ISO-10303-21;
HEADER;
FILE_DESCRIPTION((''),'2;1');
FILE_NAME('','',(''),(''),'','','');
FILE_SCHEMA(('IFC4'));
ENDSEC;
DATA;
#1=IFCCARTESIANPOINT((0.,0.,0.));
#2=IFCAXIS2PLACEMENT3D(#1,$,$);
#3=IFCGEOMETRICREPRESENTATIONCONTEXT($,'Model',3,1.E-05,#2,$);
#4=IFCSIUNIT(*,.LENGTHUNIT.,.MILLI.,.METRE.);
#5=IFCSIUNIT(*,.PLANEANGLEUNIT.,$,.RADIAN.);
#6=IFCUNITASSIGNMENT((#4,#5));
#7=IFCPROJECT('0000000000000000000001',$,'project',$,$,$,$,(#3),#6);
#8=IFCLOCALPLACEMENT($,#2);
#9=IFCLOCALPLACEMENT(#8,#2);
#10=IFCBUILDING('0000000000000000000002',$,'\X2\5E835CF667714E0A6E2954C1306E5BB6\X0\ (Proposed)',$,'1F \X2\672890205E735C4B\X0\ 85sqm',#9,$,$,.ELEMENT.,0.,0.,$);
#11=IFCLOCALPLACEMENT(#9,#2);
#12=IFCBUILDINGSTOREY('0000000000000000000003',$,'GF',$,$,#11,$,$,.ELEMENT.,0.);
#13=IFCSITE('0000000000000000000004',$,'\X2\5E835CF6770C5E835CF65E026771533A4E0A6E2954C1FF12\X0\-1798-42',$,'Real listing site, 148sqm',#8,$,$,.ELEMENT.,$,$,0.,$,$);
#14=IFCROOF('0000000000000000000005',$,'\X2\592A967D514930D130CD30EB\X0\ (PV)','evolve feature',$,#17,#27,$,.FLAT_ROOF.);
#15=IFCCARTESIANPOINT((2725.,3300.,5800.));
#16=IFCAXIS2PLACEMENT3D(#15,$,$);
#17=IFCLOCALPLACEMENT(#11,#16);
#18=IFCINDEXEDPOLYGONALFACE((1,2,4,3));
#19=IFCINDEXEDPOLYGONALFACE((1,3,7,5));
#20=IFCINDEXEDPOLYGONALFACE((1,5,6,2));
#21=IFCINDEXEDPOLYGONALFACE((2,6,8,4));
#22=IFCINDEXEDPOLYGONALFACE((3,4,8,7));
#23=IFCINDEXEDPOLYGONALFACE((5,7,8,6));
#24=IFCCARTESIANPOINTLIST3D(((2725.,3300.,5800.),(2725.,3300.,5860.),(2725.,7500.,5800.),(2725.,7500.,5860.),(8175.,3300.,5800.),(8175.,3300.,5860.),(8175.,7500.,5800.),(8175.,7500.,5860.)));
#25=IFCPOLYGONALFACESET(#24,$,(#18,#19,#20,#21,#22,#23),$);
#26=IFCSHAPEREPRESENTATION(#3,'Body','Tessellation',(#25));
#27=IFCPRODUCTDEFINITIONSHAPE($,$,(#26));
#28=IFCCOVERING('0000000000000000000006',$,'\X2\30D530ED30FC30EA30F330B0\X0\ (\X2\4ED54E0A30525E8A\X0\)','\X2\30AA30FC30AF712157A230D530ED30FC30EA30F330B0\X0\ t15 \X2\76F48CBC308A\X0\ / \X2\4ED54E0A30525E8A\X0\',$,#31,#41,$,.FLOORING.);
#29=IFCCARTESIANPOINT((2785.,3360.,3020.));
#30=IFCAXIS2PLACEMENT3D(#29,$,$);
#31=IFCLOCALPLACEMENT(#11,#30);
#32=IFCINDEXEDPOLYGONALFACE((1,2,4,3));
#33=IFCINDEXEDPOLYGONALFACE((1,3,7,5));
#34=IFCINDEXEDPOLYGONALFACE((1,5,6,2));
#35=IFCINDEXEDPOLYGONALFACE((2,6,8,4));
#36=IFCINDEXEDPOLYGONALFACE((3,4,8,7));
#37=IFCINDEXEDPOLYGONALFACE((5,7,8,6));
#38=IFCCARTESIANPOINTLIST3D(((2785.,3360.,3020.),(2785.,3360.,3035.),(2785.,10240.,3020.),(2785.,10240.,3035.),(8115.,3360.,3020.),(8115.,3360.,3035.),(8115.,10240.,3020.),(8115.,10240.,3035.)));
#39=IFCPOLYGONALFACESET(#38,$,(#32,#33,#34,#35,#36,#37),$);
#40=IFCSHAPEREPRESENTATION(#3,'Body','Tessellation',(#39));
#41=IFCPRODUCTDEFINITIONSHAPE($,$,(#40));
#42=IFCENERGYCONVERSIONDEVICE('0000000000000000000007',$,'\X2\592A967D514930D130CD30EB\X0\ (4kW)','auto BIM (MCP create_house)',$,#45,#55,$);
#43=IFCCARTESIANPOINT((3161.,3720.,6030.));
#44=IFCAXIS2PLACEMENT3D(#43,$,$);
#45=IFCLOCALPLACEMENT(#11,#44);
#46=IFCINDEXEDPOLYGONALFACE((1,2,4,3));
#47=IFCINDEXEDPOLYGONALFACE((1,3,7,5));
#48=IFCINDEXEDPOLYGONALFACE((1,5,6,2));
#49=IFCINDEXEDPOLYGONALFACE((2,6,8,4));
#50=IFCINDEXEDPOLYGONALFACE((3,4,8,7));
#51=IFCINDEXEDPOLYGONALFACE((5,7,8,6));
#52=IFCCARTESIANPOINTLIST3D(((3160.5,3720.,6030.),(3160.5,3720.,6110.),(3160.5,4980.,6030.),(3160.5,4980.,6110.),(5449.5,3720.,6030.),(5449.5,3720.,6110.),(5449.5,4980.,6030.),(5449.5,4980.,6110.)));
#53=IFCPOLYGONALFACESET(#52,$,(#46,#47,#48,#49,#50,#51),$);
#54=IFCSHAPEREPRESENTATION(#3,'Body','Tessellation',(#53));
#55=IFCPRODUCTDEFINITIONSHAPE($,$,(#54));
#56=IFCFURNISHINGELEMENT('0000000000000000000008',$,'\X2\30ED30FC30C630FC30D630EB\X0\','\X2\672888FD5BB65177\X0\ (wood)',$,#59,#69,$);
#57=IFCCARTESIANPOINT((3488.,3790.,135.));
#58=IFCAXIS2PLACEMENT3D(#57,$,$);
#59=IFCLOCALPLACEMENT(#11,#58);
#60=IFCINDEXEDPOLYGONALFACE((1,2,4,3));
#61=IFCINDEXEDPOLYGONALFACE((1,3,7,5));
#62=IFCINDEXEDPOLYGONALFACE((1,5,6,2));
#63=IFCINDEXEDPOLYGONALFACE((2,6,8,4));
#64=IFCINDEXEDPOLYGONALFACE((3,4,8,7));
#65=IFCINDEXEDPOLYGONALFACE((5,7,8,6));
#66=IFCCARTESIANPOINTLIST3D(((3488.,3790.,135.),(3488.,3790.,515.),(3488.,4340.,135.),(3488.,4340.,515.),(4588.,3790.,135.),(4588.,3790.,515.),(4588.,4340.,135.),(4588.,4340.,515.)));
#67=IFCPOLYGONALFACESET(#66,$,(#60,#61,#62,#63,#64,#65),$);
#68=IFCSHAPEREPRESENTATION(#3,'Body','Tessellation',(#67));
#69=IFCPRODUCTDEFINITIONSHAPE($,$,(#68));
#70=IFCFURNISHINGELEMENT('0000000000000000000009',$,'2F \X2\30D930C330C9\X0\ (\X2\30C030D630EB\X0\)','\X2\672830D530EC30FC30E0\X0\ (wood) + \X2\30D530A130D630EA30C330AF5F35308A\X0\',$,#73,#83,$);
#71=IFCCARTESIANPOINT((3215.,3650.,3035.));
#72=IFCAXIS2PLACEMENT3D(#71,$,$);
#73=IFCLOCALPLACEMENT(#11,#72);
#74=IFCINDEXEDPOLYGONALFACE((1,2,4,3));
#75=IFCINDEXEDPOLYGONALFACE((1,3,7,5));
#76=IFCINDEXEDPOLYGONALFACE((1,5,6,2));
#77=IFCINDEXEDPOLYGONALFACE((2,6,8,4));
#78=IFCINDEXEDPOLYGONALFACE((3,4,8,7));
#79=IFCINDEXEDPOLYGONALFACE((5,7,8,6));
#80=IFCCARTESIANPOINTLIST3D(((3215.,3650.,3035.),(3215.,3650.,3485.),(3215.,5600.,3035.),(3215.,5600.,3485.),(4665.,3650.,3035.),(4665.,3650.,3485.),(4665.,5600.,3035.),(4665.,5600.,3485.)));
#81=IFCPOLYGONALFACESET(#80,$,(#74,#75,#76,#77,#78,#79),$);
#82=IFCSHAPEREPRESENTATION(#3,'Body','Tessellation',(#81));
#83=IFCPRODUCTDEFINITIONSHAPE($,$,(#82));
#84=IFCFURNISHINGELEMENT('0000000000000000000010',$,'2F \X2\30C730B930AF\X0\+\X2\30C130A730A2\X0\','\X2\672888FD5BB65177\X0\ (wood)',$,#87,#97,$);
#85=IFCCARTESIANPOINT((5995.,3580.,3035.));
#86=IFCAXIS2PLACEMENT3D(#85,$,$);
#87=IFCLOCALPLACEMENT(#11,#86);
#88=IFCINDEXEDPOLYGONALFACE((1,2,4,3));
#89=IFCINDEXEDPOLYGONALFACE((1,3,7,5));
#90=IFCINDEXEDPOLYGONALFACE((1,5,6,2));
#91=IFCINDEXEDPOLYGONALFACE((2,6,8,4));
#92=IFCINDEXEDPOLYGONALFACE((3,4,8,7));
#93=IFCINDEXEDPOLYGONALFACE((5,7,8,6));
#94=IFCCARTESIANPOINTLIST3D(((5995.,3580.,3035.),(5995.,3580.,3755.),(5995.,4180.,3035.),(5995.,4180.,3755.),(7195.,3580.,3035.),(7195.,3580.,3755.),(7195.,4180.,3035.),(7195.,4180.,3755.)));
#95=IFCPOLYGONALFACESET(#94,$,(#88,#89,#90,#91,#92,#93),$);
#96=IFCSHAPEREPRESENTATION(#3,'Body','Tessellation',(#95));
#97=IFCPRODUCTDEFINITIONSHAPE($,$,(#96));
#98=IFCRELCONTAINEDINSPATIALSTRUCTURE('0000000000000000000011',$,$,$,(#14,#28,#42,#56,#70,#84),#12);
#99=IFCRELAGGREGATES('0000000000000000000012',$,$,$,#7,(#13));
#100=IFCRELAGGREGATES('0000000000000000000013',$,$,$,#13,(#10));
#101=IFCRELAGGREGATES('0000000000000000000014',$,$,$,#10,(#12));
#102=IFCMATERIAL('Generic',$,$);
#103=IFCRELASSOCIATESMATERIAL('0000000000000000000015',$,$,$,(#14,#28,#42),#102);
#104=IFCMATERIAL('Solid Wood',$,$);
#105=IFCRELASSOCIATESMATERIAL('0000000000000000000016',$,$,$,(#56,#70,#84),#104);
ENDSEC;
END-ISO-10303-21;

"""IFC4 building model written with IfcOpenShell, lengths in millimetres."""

from ifc_helpers import new_model, si_unit, frame, frame_2d, origin, place, context, project, spatial, rectangle, extrude, material, element, save


model = new_model("IFC4")

# Units and contexts
model_context = context("Model", 3, precision=1e-05, world=origin())
ifc_project = project(units=[si_unit("LENGTHUNIT", "METRE", prefix="MILLI"), si_unit("PLANEANGLEUNIT", "RADIAN")], contexts=[model_context])

# Site, building, storey
site_placement = place(None, origin())
site = spatial("IfcSite", under=ifc_project, at=site_placement, Name="広島県広島市東区上温品２-1798-42", ObjectType="Real listing site, 148sqm", CompositionType="ELEMENT", RefElevation=0.0)
building_placement = place(site_placement, origin())
building = spatial("IfcBuilding", under=site, at=building_placement, Name="広島東上温品の家 (Proposed)", ObjectType="1F 木造平屋 85sqm", CompositionType="ELEMENT", ElevationOfRefHeight=0.0, ElevationOfTerrain=0.0)
storey_placement = place(building_placement, origin())
storey = spatial("IfcBuildingStorey", under=building, at=storey_placement, Name="GF", CompositionType="ELEMENT", Elevation=0.0)

# Shared definitions
ifc_material_1 = material(Name="Solid Wood")

# Shared definitions
ifc_material_2 = material(Name="Generic")

# Roof
roof_1_placement = place(storey_placement, frame((2725.0, 3300.0, 5800.0)))
element("IfcRoof", 1, at=roof_1_placement, inside=storey, material=ifc_material_2, Name="太陽光パネル (PV)", Description="evolve feature", PredefinedType="FLAT_ROOF", context=model_context, shape_type="SweptSolid", body=[
    extrude(rectangle(XDim=5450.0, YDim=4200.0, at=frame_2d((2725.0, 2100.0))), frame((2725.0, 3300.0, 5800.0)), (0.0, 0.0, 1.0), 60.0),
])

# Covering
covering_placement = place(storey_placement, frame((2785.0, 3360.0, 3020.0)))
element("IfcCovering", 2, at=covering_placement, inside=storey, material=ifc_material_2, Name="フローリング (仕上げ床)", Description="オーク無垢フローリング t15 直貼り / 仕上げ床", PredefinedType="FLOORING", context=model_context, shape_type="SweptSolid", body=[
    extrude(rectangle(XDim=5330.0, YDim=6880.0, at=frame_2d((2665.0, 3440.0))), frame((2785.0, 3360.0, 3020.0)), (0.0, 0.0, 1.0), 15.0),
])

# Energy conversion device
energy_conversion_device_placement = place(storey_placement, frame((3161.0, 3720.0, 6030.0)))
element("IfcEnergyConversionDevice", 3, at=energy_conversion_device_placement, inside=storey, material=ifc_material_2, Name="太陽光パネル (4kW)", Description="auto BIM (MCP create_house)", context=model_context, shape_type="SweptSolid", body=[
    extrude(rectangle(XDim=2289.0, YDim=1260.0, at=frame_2d((1144.0, 630.0))), frame((3161.0, 3720.0, 6030.0)), (0.0, 0.0, 1.0), 80.0),
])

# Furnishing elements
furnishing_1_placement = place(storey_placement, frame((3488.0, 3790.0, 135.0)))
element("IfcFurnishingElement", 4, at=furnishing_1_placement, inside=storey, material=ifc_material_1, Name="ローテーブル", Description="木製家具 (wood)", context=model_context, shape_type="SweptSolid", body=[
    extrude(rectangle(XDim=1100.0, YDim=550.0, at=frame_2d((550.0, 275.0))), frame((3488.0, 3790.0, 135.0)), (0.0, 0.0, 1.0), 380.0),
])
furnishing_2_placement = place(storey_placement, frame((3215.0, 3650.0, 3035.0)))
element("IfcFurnishingElement", 5, at=furnishing_2_placement, inside=storey, material=ifc_material_1, Name="2F ベッド (ダブル)", Description="木フレーム (wood) + ファブリック張り", context=model_context, shape_type="SweptSolid", body=[
    extrude(rectangle(XDim=1450.0, YDim=1950.0, at=frame_2d((725.0, 975.0))), frame((3215.0, 3650.0, 3035.0)), (0.0, 0.0, 1.0), 450.0),
])
furnishing_3_placement = place(storey_placement, frame((5995.0, 3580.0, 3035.0)))
element("IfcFurnishingElement", 6, at=furnishing_3_placement, inside=storey, material=ifc_material_1, Name="2F デスク+チェア", Description="木製家具 (wood)", context=model_context, shape_type="SweptSolid", body=[
    extrude(rectangle(XDim=1200.0, YDim=600.0, at=frame_2d((600.0, 300.0))), frame((5995.0, 3580.0, 3035.0)), (0.0, 0.0, 1.0), 720.0),
])

save(model, "model.ifc")
